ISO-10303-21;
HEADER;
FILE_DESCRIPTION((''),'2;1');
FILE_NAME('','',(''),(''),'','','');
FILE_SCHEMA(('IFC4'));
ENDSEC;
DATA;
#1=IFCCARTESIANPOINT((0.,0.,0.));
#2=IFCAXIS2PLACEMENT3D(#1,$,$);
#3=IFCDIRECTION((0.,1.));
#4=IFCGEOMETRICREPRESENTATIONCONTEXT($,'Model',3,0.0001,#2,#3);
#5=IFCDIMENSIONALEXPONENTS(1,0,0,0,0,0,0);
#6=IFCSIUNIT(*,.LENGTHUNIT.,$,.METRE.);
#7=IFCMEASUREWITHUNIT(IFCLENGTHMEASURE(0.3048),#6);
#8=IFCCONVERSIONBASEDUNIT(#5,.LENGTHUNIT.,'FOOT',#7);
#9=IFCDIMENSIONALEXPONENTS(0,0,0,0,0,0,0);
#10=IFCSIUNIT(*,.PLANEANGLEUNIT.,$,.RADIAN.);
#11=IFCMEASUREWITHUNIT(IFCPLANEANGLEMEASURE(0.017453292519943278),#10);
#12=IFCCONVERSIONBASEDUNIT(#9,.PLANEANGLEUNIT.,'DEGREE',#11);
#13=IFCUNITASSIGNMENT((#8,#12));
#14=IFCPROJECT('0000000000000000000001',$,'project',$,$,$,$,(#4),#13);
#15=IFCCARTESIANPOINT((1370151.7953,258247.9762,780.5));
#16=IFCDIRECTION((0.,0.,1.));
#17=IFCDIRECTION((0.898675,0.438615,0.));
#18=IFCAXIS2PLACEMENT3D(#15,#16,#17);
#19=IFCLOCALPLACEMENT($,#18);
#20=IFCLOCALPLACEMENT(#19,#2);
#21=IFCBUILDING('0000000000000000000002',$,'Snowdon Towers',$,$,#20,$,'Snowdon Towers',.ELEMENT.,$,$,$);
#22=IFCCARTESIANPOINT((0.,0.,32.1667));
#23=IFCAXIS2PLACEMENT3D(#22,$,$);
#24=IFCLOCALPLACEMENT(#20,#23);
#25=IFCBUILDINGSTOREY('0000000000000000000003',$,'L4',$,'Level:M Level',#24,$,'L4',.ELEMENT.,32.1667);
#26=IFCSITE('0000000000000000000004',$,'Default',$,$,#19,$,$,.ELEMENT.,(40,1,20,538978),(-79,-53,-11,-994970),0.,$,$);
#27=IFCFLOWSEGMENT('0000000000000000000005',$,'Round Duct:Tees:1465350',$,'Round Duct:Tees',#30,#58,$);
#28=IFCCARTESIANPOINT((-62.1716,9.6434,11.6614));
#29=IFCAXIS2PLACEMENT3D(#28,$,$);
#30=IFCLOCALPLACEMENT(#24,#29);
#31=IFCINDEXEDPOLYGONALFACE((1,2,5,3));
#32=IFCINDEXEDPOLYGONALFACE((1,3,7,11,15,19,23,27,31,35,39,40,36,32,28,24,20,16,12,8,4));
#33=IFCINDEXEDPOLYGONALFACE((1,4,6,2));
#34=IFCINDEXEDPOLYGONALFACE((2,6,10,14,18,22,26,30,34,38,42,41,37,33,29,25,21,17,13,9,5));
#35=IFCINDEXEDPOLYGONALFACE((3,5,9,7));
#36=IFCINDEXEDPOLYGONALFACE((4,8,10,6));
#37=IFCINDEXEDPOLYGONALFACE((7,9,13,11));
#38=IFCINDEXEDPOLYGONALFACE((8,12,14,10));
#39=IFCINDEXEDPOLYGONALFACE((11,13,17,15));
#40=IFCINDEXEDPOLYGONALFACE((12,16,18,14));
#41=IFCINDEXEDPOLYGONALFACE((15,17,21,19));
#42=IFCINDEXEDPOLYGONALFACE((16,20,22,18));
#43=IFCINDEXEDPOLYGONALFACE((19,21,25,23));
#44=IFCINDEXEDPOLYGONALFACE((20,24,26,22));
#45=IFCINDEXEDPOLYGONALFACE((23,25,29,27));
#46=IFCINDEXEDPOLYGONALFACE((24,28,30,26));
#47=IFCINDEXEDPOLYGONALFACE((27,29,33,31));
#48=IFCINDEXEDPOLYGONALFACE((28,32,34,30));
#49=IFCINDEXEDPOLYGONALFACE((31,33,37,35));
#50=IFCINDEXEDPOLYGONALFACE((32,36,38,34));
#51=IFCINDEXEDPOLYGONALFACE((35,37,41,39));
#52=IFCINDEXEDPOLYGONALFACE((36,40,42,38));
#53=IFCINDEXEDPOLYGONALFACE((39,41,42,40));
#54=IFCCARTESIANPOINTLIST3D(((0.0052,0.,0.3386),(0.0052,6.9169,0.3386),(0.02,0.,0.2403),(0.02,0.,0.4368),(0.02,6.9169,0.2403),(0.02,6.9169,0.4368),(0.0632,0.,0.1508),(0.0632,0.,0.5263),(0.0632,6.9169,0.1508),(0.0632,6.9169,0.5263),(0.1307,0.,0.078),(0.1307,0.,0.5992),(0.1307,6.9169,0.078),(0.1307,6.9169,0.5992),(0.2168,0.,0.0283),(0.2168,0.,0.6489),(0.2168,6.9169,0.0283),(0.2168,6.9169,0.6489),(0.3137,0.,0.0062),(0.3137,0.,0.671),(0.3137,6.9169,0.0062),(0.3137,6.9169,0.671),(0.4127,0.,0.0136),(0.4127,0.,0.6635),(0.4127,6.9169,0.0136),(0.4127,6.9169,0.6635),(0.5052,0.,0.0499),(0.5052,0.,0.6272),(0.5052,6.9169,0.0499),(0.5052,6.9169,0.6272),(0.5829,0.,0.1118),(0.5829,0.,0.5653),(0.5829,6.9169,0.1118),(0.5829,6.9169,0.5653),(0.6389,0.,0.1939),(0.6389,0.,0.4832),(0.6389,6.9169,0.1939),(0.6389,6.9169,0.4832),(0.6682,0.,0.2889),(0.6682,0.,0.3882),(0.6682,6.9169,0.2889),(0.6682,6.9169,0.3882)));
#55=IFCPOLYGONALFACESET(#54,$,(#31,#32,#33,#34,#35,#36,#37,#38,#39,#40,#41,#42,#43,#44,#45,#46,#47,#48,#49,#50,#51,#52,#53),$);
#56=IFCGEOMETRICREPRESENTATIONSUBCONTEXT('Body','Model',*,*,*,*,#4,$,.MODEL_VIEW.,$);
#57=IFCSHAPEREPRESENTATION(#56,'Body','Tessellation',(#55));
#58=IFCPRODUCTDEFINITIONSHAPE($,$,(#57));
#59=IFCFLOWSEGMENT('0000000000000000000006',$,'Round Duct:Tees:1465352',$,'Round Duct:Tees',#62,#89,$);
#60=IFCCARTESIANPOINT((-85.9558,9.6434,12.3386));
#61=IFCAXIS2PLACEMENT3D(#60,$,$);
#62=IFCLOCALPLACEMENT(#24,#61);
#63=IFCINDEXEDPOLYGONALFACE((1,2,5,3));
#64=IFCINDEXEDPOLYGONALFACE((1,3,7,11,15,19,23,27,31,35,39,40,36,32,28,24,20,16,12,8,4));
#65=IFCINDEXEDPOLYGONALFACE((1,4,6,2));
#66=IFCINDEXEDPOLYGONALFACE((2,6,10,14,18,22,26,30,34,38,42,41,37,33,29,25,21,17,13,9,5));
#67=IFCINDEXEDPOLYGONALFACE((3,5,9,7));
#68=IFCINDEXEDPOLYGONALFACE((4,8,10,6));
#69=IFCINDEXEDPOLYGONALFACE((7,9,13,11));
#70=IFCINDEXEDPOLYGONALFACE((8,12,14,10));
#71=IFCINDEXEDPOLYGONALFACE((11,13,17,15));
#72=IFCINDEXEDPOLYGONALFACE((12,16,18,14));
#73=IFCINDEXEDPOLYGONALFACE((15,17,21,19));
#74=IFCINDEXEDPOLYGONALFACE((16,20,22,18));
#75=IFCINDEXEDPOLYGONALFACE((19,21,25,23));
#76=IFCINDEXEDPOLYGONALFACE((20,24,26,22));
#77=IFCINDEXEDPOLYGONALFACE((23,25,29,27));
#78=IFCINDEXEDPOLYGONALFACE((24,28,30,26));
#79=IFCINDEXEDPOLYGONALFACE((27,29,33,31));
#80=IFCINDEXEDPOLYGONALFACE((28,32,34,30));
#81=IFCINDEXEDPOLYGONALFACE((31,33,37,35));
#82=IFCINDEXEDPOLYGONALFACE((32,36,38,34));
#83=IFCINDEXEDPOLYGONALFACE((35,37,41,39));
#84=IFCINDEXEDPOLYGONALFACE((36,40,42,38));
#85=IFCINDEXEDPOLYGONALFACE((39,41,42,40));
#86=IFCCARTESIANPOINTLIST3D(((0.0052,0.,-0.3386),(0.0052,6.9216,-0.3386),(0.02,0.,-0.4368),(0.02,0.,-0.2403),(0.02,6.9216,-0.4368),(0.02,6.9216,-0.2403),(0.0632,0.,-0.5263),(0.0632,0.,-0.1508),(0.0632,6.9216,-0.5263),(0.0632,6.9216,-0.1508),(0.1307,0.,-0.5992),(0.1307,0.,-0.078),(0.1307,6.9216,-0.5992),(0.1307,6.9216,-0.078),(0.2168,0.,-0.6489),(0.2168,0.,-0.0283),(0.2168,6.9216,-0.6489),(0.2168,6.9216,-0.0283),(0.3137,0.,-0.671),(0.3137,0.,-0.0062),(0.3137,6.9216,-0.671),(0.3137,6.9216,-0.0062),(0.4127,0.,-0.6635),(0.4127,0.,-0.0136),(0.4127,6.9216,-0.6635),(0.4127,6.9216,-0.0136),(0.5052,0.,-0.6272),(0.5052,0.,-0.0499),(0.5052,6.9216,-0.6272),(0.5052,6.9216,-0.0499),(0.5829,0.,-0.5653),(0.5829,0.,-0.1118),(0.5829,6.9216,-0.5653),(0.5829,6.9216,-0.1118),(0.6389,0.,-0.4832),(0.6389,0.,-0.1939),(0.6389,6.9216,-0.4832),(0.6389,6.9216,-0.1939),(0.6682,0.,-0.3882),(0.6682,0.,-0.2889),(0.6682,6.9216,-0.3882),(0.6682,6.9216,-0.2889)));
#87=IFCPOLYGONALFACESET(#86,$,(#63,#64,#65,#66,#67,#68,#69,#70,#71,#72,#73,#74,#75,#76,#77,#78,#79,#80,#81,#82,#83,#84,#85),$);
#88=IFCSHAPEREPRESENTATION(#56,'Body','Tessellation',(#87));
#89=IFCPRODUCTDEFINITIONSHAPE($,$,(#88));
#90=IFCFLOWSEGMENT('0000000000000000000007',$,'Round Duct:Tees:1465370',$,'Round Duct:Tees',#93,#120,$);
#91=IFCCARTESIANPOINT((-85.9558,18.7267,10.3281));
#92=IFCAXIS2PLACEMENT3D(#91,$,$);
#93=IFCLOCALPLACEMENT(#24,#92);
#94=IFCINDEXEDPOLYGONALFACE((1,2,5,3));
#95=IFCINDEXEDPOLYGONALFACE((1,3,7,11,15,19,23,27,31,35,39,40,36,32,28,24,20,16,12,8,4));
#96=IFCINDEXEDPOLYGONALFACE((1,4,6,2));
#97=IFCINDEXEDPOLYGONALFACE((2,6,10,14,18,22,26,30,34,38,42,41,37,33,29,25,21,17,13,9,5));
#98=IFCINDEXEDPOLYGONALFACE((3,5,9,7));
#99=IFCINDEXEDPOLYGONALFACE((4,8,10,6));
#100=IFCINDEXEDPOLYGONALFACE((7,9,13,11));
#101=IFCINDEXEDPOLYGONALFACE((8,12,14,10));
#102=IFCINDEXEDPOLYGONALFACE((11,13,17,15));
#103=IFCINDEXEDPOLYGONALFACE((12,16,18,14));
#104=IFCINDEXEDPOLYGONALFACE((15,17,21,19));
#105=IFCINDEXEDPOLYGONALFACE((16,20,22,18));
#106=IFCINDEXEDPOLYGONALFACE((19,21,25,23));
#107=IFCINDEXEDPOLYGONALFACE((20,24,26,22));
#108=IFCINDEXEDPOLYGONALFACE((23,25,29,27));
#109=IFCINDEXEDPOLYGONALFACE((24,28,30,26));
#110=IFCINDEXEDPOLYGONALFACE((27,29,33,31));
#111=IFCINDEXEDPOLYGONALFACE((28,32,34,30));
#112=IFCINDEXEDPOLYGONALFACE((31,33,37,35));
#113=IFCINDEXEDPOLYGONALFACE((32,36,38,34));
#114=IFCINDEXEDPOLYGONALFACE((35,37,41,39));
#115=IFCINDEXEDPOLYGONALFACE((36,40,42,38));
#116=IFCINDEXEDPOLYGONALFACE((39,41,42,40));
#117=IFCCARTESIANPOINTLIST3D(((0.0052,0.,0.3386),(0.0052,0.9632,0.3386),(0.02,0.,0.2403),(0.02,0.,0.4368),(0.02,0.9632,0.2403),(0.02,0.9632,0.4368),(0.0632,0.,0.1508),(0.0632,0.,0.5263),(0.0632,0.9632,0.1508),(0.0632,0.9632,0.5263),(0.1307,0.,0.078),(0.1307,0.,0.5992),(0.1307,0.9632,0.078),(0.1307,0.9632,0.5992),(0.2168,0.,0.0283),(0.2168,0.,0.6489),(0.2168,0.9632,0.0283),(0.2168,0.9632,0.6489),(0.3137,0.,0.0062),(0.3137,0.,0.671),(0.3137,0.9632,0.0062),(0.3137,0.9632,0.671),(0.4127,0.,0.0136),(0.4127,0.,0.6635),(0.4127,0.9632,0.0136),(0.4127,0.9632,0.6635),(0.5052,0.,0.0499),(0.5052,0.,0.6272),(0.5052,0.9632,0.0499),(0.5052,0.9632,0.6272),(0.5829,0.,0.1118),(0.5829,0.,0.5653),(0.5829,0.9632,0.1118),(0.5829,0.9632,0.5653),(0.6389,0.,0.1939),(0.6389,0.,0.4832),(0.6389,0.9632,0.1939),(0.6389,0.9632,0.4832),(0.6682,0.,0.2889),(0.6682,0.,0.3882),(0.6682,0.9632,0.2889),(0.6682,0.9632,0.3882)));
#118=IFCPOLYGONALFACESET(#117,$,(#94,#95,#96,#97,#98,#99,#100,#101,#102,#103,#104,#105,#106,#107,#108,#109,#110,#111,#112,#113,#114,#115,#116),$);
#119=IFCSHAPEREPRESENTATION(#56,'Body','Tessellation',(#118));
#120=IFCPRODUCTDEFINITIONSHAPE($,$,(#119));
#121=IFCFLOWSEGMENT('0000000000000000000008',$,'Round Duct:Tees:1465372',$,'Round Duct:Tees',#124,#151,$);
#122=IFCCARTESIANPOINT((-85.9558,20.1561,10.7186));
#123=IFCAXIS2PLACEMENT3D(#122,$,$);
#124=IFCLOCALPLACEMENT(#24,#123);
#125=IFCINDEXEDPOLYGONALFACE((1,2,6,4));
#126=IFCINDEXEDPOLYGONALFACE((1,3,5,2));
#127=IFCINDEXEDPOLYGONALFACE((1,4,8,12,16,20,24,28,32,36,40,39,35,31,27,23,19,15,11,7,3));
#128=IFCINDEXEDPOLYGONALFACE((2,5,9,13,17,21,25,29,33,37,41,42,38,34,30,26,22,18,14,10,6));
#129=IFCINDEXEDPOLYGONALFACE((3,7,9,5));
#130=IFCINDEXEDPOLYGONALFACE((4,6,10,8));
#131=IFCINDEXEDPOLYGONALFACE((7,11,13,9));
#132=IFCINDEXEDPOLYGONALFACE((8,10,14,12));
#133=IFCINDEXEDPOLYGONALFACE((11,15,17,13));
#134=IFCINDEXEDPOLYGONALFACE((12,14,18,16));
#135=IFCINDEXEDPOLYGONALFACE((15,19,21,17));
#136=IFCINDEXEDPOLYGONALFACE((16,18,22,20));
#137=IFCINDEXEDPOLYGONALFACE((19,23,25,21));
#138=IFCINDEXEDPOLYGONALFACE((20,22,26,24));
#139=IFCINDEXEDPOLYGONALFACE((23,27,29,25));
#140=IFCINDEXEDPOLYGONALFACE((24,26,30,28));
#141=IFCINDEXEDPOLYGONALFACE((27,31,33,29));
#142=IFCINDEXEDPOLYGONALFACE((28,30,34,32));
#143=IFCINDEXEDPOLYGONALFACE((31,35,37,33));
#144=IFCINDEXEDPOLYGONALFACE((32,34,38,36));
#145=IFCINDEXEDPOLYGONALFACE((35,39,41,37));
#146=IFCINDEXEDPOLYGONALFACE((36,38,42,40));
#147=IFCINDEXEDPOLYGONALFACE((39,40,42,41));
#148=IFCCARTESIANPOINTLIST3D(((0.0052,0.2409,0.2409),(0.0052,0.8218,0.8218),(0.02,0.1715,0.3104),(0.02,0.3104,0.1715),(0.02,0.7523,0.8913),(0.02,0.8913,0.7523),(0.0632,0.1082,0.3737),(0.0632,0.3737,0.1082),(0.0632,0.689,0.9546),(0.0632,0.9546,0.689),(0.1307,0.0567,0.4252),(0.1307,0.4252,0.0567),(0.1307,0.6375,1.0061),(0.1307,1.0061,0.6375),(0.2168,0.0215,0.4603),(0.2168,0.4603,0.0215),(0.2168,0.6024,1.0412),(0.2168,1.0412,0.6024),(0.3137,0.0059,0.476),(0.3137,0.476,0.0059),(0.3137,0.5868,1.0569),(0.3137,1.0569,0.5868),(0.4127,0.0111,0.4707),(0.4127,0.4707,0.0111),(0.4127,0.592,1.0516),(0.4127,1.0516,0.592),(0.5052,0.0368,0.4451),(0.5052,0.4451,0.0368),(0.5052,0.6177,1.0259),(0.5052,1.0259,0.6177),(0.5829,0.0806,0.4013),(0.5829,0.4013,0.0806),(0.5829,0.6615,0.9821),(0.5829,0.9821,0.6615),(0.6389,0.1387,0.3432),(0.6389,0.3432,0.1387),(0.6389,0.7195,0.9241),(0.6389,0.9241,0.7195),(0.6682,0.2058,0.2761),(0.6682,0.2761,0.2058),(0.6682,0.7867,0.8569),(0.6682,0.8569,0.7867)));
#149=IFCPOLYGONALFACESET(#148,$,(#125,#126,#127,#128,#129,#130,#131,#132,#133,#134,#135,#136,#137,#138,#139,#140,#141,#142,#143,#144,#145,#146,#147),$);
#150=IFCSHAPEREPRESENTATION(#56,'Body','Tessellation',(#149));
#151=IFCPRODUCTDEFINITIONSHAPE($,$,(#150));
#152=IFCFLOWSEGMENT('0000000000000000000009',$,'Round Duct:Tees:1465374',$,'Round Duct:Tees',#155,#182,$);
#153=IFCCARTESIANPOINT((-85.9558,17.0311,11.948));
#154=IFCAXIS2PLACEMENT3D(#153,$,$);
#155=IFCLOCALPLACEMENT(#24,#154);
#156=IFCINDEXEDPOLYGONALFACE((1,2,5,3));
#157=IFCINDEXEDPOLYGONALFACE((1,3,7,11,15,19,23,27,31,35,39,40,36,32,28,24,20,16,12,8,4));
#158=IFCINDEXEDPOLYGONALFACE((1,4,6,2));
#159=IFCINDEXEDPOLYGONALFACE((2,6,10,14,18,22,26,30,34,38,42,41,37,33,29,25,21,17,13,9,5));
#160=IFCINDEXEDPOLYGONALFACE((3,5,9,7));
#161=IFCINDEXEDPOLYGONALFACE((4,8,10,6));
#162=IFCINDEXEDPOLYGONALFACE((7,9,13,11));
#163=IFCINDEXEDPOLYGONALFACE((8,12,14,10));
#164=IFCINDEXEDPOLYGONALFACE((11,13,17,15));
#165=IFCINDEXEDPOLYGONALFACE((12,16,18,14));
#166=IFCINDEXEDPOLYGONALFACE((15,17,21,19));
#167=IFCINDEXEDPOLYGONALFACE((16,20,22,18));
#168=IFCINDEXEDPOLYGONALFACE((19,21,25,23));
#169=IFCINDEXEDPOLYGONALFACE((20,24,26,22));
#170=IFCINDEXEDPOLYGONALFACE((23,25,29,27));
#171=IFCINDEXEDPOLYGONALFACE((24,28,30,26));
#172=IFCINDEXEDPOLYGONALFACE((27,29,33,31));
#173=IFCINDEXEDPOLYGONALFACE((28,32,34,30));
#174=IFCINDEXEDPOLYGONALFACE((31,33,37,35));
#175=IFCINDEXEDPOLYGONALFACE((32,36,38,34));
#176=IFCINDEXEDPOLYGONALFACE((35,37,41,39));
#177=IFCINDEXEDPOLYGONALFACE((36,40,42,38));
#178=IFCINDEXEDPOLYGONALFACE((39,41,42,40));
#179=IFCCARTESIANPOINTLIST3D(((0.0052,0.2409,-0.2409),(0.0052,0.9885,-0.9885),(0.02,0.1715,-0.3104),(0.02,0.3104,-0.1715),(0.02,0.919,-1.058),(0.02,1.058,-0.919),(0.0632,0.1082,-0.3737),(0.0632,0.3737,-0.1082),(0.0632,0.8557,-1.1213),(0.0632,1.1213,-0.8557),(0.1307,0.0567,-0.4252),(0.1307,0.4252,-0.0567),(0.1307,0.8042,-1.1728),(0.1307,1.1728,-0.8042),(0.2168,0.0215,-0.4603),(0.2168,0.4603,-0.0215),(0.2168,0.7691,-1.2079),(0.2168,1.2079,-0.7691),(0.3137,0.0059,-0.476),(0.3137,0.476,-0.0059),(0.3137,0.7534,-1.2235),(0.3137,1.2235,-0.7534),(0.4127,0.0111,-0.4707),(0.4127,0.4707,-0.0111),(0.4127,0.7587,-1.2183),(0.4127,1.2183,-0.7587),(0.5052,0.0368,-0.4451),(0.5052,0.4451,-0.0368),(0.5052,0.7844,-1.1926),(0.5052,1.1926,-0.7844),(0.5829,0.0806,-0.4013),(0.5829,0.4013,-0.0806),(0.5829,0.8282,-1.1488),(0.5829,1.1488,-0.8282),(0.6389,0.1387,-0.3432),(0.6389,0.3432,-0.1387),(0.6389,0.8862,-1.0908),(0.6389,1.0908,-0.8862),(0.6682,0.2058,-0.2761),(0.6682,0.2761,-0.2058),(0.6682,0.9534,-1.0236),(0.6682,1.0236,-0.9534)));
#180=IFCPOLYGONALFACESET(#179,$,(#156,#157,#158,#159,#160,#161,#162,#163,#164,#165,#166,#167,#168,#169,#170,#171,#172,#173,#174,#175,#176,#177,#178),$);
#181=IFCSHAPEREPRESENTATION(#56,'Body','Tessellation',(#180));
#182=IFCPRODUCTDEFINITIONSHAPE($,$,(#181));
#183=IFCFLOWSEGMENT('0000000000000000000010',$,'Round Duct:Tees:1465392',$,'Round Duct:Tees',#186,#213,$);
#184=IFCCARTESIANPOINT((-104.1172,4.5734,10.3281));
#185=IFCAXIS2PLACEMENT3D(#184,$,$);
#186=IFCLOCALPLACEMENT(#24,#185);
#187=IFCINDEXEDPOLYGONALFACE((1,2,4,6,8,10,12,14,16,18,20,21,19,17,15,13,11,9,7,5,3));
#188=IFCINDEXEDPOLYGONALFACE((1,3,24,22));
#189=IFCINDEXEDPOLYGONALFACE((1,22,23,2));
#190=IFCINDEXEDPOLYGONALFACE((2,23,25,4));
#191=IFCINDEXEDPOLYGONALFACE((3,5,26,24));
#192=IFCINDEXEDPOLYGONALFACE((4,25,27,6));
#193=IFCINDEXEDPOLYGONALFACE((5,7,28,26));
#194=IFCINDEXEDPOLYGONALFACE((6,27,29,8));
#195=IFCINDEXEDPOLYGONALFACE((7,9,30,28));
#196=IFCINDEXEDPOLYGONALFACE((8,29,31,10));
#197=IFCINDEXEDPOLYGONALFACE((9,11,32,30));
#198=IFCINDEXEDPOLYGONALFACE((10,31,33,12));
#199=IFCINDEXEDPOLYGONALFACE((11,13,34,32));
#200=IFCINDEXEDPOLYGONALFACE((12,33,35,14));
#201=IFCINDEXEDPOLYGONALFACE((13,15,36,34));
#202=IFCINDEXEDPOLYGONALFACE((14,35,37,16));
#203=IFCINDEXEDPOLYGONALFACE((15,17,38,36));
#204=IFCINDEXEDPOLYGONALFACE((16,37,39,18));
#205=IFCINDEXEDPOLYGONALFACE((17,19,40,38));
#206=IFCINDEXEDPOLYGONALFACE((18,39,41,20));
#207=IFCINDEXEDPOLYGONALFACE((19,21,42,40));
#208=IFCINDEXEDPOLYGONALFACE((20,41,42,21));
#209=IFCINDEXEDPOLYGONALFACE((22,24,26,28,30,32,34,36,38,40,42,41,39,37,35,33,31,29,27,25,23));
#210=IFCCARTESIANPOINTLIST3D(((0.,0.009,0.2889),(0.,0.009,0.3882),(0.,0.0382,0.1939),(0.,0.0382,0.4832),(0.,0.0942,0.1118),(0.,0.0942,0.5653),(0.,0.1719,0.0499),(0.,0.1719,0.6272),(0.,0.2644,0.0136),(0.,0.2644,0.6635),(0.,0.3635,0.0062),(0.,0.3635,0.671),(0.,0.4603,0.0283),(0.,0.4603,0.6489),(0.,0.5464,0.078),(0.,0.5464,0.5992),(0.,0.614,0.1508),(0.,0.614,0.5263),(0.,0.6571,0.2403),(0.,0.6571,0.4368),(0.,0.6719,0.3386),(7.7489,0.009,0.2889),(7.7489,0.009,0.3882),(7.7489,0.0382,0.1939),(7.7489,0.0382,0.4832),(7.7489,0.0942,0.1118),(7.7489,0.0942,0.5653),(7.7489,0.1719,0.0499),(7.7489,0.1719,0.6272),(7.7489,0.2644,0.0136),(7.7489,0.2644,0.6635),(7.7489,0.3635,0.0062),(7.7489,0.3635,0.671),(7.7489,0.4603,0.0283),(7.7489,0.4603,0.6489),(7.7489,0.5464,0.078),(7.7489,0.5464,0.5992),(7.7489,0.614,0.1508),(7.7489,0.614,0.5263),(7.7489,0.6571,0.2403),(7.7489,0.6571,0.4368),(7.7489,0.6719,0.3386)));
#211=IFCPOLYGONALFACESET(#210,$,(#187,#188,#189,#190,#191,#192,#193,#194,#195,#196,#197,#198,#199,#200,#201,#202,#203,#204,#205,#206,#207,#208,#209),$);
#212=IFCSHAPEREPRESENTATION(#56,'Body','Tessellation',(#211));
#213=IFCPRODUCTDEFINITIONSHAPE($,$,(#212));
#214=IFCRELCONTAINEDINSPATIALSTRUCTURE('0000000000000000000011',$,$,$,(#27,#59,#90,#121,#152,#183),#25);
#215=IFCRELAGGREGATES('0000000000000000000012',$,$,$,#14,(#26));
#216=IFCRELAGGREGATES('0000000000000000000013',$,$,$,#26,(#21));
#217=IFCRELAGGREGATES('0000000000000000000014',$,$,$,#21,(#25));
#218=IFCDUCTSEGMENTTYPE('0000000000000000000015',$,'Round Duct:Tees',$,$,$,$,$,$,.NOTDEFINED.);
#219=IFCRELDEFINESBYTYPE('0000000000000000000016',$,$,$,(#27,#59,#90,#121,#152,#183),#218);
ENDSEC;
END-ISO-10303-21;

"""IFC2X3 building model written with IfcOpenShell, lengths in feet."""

from ifc_helpers import new_model, entity, si_unit, converted_unit, direction, frame, frame_2d, origin, origin_2d_with_axis, place, context, subcontext, project, spatial, circle, extrude, type_object, element, save


model = new_model("IFC2X3")

# Units and contexts
model_context = context("Model", 3, precision=0.0001, world=origin(), true_north=direction((0.0, 1.0)))
body_context = subcontext(model_context, "Body", "Model", "MODEL_VIEW")
ifc_project = project(units=[converted_unit("LENGTHUNIT", "FOOT", entity("IfcLengthMeasure", 0.3048), si_unit("LENGTHUNIT", "METRE"), dimensions=[1, 0, 0, 0, 0, 0, 0]), converted_unit("PLANEANGLEUNIT", "DEGREE", entity("IfcPlaneAngleMeasure", 0.017453292519943278), si_unit("PLANEANGLEUNIT", "RADIAN"), dimensions=[0, 0, 0, 0, 0, 0, 0])], contexts=[model_context])

# Site, building, storey
site_placement = place(None, frame((1370151.7953, 258247.9762, 780.5), z_axis=(0.0, 0.0, 1.0), x_axis=(0.898675, 0.438615, 0.0)))
site = spatial("IfcSite", under=ifc_project, at=site_placement, Name="Default", CompositionType="ELEMENT", RefLatitude=(40, 1, 20, 538978), RefLongitude=(-79, -53, -11, -994970), RefElevation=0.0)
building_placement = place(site_placement, origin())
building = spatial("IfcBuilding", under=site, at=building_placement, Name="Snowdon Towers", LongName="Snowdon Towers", CompositionType="ELEMENT")
storey_placement = place(building_placement, frame((0.0, 0.0, 32.1667)))
storey = spatial("IfcBuildingStorey", under=building, at=storey_placement, Name="L4", ObjectType="Level:M Level", LongName="L4", CompositionType="ELEMENT", Elevation=32.1667)

# Flow segments
duct_segment_type = type_object("IfcDuctSegmentType", Name="Round Duct:Tees", PredefinedType="NOTDEFINED")
flow_segment_1_placement = place(storey_placement, frame((-62.1716, 9.6434, 11.6614)))
element("IfcFlowSegment", 1, at=flow_segment_1_placement, inside=storey, type_object=duct_segment_type, Name="Round Duct:Tees:1465350", ObjectType="Round Duct:Tees", context=body_context, shape_type="SweptSolid", body=[
    extrude(circle(Radius=0.3333, at=frame_2d((0.0, 0.0), x_axis=(1.0, 0.0))), frame((0.3386, 0.0, 0.3386), z_axis=(0.0, 1.0, 0.0), x_axis=(-1.0, 0.0, 0.0)), (0.0, 0.0, 1.0), 6.9169),
])
flow_segment_2_placement = place(storey_placement, frame((-85.9558, 9.6434, 12.3386)))
element("IfcFlowSegment", 2, at=flow_segment_2_placement, inside=storey, type_object=duct_segment_type, Name="Round Duct:Tees:1465352", ObjectType="Round Duct:Tees", context=body_context, shape_type="SweptSolid", body=[
    extrude(circle(Radius=0.3333, at=frame_2d((0.0, 0.0), x_axis=(1.0, 0.0))), frame((0.3386, 0.0, -0.3386), z_axis=(0.0, 1.0, 0.0), x_axis=(-1.0, 0.0, 0.0)), (0.0, 0.0, 1.0), 6.9216),
])
flow_segment_3_placement = place(storey_placement, frame((-85.9558, 18.7267, 10.3281)))
element("IfcFlowSegment", 3, at=flow_segment_3_placement, inside=storey, type_object=duct_segment_type, Name="Round Duct:Tees:1465370", ObjectType="Round Duct:Tees", context=body_context, shape_type="SweptSolid", body=[
    extrude(circle(Radius=0.3333, at=origin_2d_with_axis()), frame((0.3386, 0.0, 0.3386), z_axis=(0.0, 1.0, 0.0), x_axis=(-1.0, 0.0, 0.0)), (0.0, 0.0, 1.0), 0.9632),
])
flow_segment_4_placement = place(storey_placement, frame((-85.9558, 20.1561, 10.7186)))
element("IfcFlowSegment", 4, at=flow_segment_4_placement, inside=storey, type_object=duct_segment_type, Name="Round Duct:Tees:1465372", ObjectType="Round Duct:Tees", context=body_context, shape_type="SweptSolid", body=[
    extrude(circle(Radius=0.3333, at=frame_2d((0.0, 0.0), x_axis=(1.0, 0.0))), frame((0.3386, 0.2409, 0.2409), z_axis=(0.0, 0.707107, 0.707107), x_axis=(-1.0, 0.0, 0.0)), (0.0, 0.0, 1.0), 0.8215),
])
flow_segment_5_placement = place(storey_placement, frame((-85.9558, 17.0311, 11.948)))
element("IfcFlowSegment", 5, at=flow_segment_5_placement, inside=storey, type_object=duct_segment_type, Name="Round Duct:Tees:1465374", ObjectType="Round Duct:Tees", context=body_context, shape_type="SweptSolid", body=[
    extrude(circle(Radius=0.3333, at=frame_2d((0.0, 0.0), x_axis=(1.0, 0.0))), frame((0.3386, 0.2409, -0.2409), z_axis=(0.0, 0.707107, -0.707107), x_axis=(-1.0, 0.0, 0.0)), (0.0, 0.0, 1.0), 1.0572),
])
flow_segment_6_placement = place(storey_placement, frame((-104.1172, 4.5734, 10.3281)))
element("IfcFlowSegment", 6, at=flow_segment_6_placement, inside=storey, type_object=duct_segment_type, Name="Round Duct:Tees:1465392", ObjectType="Round Duct:Tees", context=body_context, shape_type="SweptSolid", body=[
    extrude(circle(Radius=0.3333, at=frame_2d((0.0, 0.0), x_axis=(1.0, 0.0))), frame((0.0, 0.3386, 0.3386), z_axis=(1.0, 0.0, 0.0), x_axis=(0.0, 1.0, 0.0)), (0.0, 0.0, 1.0), 7.7489),
])

save(model, "model.ifc")
